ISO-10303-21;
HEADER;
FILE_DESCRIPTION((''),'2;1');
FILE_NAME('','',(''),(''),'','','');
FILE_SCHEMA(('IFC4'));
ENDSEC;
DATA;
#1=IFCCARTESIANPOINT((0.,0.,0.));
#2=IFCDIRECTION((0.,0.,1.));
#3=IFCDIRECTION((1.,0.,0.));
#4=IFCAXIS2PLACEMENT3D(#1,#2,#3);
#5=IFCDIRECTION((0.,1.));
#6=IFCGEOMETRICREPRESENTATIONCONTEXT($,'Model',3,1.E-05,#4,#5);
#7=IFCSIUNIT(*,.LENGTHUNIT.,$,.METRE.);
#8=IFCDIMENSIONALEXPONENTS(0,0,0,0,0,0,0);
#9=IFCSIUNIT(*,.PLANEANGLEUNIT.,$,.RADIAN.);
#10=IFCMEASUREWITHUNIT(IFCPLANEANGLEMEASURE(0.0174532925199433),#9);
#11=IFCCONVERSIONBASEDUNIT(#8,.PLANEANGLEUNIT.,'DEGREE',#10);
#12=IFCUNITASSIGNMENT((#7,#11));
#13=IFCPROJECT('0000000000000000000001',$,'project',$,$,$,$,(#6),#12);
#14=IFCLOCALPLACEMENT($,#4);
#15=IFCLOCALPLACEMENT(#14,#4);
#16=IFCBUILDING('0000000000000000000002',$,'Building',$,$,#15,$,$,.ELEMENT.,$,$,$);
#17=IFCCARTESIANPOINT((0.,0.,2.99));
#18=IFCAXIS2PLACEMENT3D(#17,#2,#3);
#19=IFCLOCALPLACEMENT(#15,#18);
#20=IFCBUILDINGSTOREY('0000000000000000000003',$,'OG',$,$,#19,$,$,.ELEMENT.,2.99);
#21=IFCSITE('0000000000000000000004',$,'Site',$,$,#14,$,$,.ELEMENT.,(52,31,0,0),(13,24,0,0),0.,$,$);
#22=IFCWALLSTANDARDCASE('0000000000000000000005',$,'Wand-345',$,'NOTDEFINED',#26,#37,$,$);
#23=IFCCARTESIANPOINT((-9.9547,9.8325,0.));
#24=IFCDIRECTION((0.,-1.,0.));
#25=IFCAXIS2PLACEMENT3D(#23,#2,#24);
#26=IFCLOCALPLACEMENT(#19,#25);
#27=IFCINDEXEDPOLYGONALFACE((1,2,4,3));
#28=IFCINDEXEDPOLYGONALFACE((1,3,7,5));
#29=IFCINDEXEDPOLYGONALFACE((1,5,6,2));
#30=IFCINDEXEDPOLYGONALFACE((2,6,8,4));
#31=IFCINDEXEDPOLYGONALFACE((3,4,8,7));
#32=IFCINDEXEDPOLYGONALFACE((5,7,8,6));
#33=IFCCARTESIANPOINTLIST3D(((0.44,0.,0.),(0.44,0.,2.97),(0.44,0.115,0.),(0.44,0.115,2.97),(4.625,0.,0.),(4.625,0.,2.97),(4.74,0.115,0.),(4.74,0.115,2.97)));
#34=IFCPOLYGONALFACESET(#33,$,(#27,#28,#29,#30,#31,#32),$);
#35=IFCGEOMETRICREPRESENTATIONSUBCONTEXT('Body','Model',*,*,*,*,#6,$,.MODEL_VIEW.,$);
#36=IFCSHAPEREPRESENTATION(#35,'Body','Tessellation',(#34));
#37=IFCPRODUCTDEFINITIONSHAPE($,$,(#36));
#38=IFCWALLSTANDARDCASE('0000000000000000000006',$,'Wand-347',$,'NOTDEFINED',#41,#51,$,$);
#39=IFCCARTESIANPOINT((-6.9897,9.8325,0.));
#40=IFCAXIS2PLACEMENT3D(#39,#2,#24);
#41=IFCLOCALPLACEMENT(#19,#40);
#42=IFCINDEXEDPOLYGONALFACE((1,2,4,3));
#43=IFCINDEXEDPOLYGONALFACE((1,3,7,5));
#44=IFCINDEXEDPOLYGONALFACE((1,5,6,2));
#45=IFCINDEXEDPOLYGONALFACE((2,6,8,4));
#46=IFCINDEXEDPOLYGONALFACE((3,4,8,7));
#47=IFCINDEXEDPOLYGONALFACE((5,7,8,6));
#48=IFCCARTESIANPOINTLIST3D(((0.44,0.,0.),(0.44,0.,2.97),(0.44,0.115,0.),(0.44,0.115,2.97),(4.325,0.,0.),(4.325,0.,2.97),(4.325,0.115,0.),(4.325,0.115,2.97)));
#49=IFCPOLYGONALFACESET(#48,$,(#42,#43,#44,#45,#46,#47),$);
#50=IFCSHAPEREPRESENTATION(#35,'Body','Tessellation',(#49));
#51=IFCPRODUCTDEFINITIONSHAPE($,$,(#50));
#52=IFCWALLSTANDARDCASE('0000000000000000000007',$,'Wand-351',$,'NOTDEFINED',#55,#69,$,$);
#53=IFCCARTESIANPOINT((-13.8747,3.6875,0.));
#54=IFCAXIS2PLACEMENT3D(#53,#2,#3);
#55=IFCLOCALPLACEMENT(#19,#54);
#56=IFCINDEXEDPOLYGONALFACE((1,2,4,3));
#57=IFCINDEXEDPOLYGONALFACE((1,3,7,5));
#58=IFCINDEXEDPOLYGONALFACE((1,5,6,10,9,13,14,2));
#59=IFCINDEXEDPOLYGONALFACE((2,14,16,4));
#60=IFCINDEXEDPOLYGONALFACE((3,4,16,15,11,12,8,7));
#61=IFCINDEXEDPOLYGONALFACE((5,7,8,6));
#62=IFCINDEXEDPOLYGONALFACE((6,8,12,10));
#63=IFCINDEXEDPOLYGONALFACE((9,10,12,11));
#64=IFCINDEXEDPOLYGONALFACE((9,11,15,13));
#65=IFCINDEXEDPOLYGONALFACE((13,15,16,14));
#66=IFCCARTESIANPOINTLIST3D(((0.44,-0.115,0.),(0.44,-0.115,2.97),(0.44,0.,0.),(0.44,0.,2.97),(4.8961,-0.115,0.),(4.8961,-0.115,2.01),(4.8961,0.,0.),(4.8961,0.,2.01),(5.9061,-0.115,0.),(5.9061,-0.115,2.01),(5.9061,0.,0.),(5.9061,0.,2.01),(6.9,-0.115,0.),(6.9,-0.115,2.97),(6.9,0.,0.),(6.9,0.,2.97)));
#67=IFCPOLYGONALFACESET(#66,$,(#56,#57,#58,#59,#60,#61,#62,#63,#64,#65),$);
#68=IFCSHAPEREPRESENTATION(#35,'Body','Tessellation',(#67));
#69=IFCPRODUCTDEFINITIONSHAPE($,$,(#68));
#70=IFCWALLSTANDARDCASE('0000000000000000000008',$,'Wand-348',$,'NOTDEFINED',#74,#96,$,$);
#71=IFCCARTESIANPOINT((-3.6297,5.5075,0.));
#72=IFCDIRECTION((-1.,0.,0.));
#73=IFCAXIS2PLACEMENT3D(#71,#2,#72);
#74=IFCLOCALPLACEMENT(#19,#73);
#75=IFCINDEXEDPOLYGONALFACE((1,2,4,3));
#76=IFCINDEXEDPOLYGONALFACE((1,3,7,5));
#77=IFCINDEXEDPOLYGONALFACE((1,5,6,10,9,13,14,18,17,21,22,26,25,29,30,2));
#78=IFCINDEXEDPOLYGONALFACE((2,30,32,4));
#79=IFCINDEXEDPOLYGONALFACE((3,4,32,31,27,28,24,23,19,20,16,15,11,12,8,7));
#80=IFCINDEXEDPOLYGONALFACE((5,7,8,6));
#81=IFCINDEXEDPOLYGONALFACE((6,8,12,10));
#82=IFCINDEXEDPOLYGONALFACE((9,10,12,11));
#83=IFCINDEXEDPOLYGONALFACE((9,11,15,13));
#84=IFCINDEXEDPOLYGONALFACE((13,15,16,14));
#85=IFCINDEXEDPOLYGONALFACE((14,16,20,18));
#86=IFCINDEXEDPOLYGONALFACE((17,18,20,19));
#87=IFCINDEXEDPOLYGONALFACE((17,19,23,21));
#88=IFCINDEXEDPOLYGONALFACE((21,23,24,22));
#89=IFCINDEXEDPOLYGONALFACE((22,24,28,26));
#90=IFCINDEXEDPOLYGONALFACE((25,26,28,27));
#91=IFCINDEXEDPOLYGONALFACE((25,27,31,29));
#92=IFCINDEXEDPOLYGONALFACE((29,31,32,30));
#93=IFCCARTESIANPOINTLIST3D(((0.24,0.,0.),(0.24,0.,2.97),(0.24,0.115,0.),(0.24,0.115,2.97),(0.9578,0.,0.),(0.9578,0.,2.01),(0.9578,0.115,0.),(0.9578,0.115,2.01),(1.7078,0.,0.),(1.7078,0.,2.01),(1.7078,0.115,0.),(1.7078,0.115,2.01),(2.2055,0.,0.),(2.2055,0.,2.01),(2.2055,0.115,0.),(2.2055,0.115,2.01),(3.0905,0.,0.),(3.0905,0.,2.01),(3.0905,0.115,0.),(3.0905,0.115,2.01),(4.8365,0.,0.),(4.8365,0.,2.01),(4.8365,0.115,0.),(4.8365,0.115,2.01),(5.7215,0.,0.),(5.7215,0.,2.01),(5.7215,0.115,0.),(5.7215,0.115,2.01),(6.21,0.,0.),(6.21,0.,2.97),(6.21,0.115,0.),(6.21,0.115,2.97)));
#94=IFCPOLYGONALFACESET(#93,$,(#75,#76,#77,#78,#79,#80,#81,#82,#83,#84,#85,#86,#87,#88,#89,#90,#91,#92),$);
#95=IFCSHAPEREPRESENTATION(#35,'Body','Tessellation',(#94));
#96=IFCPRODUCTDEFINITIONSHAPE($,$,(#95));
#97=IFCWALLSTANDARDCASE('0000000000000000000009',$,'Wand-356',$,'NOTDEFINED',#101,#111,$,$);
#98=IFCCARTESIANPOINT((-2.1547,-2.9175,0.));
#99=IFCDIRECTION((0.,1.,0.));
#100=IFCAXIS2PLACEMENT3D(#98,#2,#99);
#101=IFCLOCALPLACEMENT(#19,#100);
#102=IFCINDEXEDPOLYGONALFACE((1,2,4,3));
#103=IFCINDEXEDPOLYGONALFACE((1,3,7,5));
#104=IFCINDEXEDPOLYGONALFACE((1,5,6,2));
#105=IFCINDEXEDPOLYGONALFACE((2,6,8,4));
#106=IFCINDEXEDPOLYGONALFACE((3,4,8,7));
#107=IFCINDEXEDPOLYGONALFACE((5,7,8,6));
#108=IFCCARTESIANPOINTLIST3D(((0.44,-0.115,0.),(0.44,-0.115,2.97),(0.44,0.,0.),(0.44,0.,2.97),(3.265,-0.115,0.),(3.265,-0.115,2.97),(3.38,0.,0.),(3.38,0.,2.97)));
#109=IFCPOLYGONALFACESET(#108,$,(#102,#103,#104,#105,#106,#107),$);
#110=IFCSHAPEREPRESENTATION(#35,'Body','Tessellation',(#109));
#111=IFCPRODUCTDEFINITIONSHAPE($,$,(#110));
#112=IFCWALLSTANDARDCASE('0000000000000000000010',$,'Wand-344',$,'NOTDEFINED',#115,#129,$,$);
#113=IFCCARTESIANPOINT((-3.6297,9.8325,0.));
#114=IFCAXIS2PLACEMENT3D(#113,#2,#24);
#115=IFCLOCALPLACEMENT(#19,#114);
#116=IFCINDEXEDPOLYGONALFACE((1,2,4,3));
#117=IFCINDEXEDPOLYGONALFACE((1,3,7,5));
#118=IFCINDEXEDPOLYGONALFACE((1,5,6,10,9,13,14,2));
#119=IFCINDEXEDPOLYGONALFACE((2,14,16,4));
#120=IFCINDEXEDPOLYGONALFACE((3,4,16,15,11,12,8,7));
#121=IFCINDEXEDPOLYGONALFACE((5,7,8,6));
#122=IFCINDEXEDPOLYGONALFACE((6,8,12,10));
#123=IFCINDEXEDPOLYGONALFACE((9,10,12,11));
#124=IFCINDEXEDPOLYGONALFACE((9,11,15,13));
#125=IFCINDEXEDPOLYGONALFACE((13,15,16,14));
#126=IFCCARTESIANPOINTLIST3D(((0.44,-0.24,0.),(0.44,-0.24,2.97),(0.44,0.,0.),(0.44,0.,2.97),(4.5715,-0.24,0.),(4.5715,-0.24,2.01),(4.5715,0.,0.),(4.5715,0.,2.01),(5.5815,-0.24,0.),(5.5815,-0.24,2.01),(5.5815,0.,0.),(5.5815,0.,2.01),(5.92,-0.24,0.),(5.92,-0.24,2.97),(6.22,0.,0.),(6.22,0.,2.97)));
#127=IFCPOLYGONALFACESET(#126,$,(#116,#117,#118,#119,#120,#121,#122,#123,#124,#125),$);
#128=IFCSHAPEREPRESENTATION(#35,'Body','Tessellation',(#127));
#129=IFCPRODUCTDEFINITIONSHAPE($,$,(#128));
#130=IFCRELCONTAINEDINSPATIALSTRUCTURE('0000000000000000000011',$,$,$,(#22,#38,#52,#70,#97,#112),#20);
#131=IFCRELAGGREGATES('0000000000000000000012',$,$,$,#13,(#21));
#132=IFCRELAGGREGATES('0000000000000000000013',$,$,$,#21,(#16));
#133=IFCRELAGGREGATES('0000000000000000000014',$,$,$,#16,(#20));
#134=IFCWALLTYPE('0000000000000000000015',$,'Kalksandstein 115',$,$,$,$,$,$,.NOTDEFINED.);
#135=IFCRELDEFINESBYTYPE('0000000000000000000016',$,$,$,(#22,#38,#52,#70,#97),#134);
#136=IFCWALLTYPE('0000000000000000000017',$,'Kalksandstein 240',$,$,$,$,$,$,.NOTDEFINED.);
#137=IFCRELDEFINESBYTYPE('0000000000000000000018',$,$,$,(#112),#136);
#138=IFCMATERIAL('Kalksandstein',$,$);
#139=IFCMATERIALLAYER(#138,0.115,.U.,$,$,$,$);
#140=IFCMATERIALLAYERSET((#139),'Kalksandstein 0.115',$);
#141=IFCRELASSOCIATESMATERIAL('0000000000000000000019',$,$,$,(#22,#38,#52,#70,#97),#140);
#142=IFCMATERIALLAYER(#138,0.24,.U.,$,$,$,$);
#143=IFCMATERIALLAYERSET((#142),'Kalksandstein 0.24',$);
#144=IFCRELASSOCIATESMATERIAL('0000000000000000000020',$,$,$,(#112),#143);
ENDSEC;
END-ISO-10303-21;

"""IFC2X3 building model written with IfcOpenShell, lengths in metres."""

from ifc_helpers import new_model, entity, si_unit, converted_unit, direction, frame, origin_with_axes, origin_2d_with_axis, place, context, subcontext, project, spatial, polyline, rectangle, outline, extrude, material, layer, layer_set, layer_usage, type_object, element, save


model = new_model("IFC2X3")

# Units and contexts
model_context = context("Model", 3, precision=1e-05, world=origin_with_axes(), true_north=direction((0.0, 1.0)))
body_context = subcontext(model_context, "Body", "Model", "MODEL_VIEW")
ifc_project = project(units=[si_unit("LENGTHUNIT", "METRE"), converted_unit("PLANEANGLEUNIT", "DEGREE", entity("IfcPlaneAngleMeasure", 0.0174532925199433), si_unit("PLANEANGLEUNIT", "RADIAN"), dimensions=[0, 0, 0, 0, 0, 0, 0])], contexts=[model_context])

# Site, building, storey
site_placement = place(None, origin_with_axes())
site = spatial("IfcSite", under=ifc_project, at=site_placement, Name="Site", CompositionType="ELEMENT", RefLatitude=(52, 31, 0, 0), RefLongitude=(13, 24, 0, 0), RefElevation=0.0)
building_placement = place(site_placement, origin_with_axes())
building = spatial("IfcBuilding", under=site, at=building_placement, Name="Building", CompositionType="ELEMENT")
storey_placement = place(building_placement, frame((0.0, 0.0, 2.99), z_axis=(0.0, 0.0, 1.0), x_axis=(1.0, 0.0, 0.0)))
storey = spatial("IfcBuildingStorey", under=building, at=storey_placement, Name="OG", CompositionType="ELEMENT", Elevation=2.99)

# Shared definitions
ifc_material_1 = material(Name="Kalksandstein")

# Shared definitions
ifc_layer_1 = layer(ifc_material_1, 0.115, ventilated="UNKNOWN")
ifc_layer_set_1 = layer_set([ifc_layer_1], Name="Kalksandstein 0.115")
wall_type_1 = type_object("IfcWallType", Name="Kalksandstein 115", PredefinedType="NOTDEFINED")

# Walls
ifc_layer_usage_1 = layer_usage(ifc_layer_set_1, "AXIS2", "NEGATIVE", 0.115)
wall_1_placement = place(storey_placement, frame((-9.9547, 9.8325, 0.0), z_axis=(0.0, 0.0, 1.0), x_axis=(0.0, -1.0, 0.0)))
element("IfcWallStandardCase", 1, at=wall_1_placement, inside=storey, type_object=wall_type_1, material=ifc_layer_usage_1, Name="Wand-345", ObjectType="NOTDEFINED", context=body_context, shape_type="SweptSolid", body=[
    extrude(outline(polyline([(0.44, 0.0), (4.625, 0.0), (4.74, 0.115), (0.44, 0.115), (0.44, 0.0)])), origin_with_axes(), (0.0, 0.0, 1.0), 2.97),
])
ifc_layer_usage_2 = layer_usage(ifc_layer_set_1, "AXIS2", "NEGATIVE", 0.115)
wall_2_placement = place(storey_placement, frame((-6.9897, 9.8325, 0.0), z_axis=(0.0, 0.0, 1.0), x_axis=(0.0, -1.0, 0.0)))
element("IfcWallStandardCase", 2, at=wall_2_placement, inside=storey, type_object=wall_type_1, material=ifc_layer_usage_2, Name="Wand-347", ObjectType="NOTDEFINED", context=body_context, shape_type="SweptSolid", body=[
    extrude(outline(polyline([(0.44, 0.0), (4.325, 0.0), (4.325, 0.115), (0.44, 0.115), (0.44, 0.0)])), origin_with_axes(), (0.0, 0.0, 1.0), 2.97),
])

# Wall, opening
ifc_layer_usage_3 = layer_usage(ifc_layer_set_1, "AXIS2", "POSITIVE", -0.115)
wall_3_placement = place(storey_placement, frame((-13.8747, 3.6875, 0.0), z_axis=(0.0, 0.0, 1.0), x_axis=(1.0, 0.0, 0.0)))
wall_3 = element("IfcWallStandardCase", 3, at=wall_3_placement, inside=storey, type_object=wall_type_1, material=ifc_layer_usage_3, Name="Wand-351", ObjectType="NOTDEFINED", context=body_context, shape_type="SweptSolid", body=[
    extrude(outline(polyline([(0.44, -0.115), (6.9, -0.115), (6.9, 0.0), (0.44, 0.0), (0.44, -0.115)])), origin_with_axes(), (0.0, 0.0, 1.0), 2.97),
])
opening_1_placement = place(wall_3_placement, frame((5.4011, 0.0, 0.0), z_axis=(0.0, 0.0, 1.0), x_axis=(1.0, 0.0, 0.0)))
element("IfcOpeningElement", 4, at=opening_1_placement, cuts=wall_3, context=body_context, shape_type="SweptSolid", body=[
    extrude(rectangle(XDim=1.01, YDim=2.01, at=origin_2d_with_axis()), frame((0.0, 0.115, 1.005), z_axis=(0.0, 1.0, 0.0), x_axis=(1.0, 0.0, 0.0)), (0.0, 0.0, -1.0), 0.345),
])

# Wall, openings
ifc_layer_usage_4 = layer_usage(ifc_layer_set_1, "AXIS2", "NEGATIVE", 0.115)
wall_4_placement = place(storey_placement, frame((-3.6297, 5.5075, 0.0), z_axis=(0.0, 0.0, 1.0), x_axis=(-1.0, 0.0, 0.0)))
wall_4 = element("IfcWallStandardCase", 5, at=wall_4_placement, inside=storey, type_object=wall_type_1, material=ifc_layer_usage_4, Name="Wand-348", ObjectType="NOTDEFINED", context=body_context, shape_type="SweptSolid", body=[
    extrude(outline(polyline([(0.24, 0.0), (6.21, 0.0), (6.21, 0.115), (0.24, 0.115), (0.24, 0.0)])), origin_with_axes(), (0.0, 0.0, 1.0), 2.97),
])
opening_2_placement = place(wall_4_placement, frame((5.279, 0.0, 0.0), z_axis=(0.0, 0.0, 1.0), x_axis=(1.0, 0.0, 0.0)))
element("IfcOpeningElement", 6, at=opening_2_placement, cuts=wall_4, context=body_context, shape_type="SweptSolid", body=[
    extrude(rectangle(XDim=0.885, YDim=2.01, at=origin_2d_with_axis()), frame((0.0, 0.115, 1.005), z_axis=(0.0, 1.0, 0.0), x_axis=(1.0, 0.0, 0.0)), (0.0, 0.0, -1.0), 0.345),
])
opening_3_placement = place(wall_4_placement, frame((2.648, 0.0, 0.0), z_axis=(0.0, 0.0, 1.0), x_axis=(1.0, 0.0, 0.0)))
element("IfcOpeningElement", 7, at=opening_3_placement, cuts=wall_4, context=body_context, shape_type="SweptSolid", body=[
    extrude(rectangle(XDim=0.885, YDim=2.01, at=origin_2d_with_axis()), frame((0.0, -0.115, 1.005), z_axis=(0.0, -1.0, 0.0), x_axis=(-1.0, 0.0, 0.0)), (0.0, 0.0, -1.0), 0.345),
])
opening_4_placement = place(wall_4_placement, frame((1.3328, 0.0, 0.0), z_axis=(0.0, 0.0, 1.0), x_axis=(1.0, 0.0, 0.0)))
element("IfcOpeningElement", 8, at=opening_4_placement, cuts=wall_4, context=body_context, shape_type="SweptSolid", body=[
    extrude(rectangle(XDim=0.75, YDim=2.01, at=origin_2d_with_axis()), frame((0.0, -0.115, 1.005), z_axis=(0.0, -1.0, 0.0), x_axis=(-1.0, 0.0, 0.0)), (0.0, 0.0, -1.0), 0.345),
])

# Wall
ifc_layer_usage_5 = layer_usage(ifc_layer_set_1, "AXIS2", "POSITIVE", -0.115)
wall_5_placement = place(storey_placement, frame((-2.1547, -2.9175, 0.0), z_axis=(0.0, 0.0, 1.0), x_axis=(0.0, 1.0, 0.0)))
element("IfcWallStandardCase", 9, at=wall_5_placement, inside=storey, type_object=wall_type_1, material=ifc_layer_usage_5, Name="Wand-356", ObjectType="NOTDEFINED", context=body_context, shape_type="SweptSolid", body=[
    extrude(outline(polyline([(0.44, -0.115), (3.265, -0.115), (3.38, 0.0), (0.44, 0.0), (0.44, -0.115)])), origin_with_axes(), (0.0, 0.0, 1.0), 2.97),
])

# Wall, opening
ifc_layer_2 = layer(ifc_material_1, 0.24, ventilated="UNKNOWN")
ifc_layer_set_2 = layer_set([ifc_layer_2], Name="Kalksandstein 0.24")
ifc_layer_usage_6 = layer_usage(ifc_layer_set_2, "AXIS2", "POSITIVE", -0.24)
wall_type_2 = type_object("IfcWallType", Name="Kalksandstein 240", PredefinedType="NOTDEFINED")
wall_6_placement = place(storey_placement, frame((-3.6297, 9.8325, 0.0), z_axis=(0.0, 0.0, 1.0), x_axis=(0.0, -1.0, 0.0)))
wall_6 = element("IfcWallStandardCase", 10, at=wall_6_placement, inside=storey, type_object=wall_type_2, material=ifc_layer_usage_6, Name="Wand-344", ObjectType="NOTDEFINED", context=body_context, shape_type="SweptSolid", body=[
    extrude(outline(polyline([(0.44, -0.24), (5.92, -0.24), (6.22, 0.0), (0.44, 0.0), (0.44, -0.24)])), origin_with_axes(), (0.0, 0.0, 1.0), 2.97),
])
opening_5_placement = place(wall_6_placement, frame((5.0765, 0.0, 0.0), z_axis=(0.0, 0.0, 1.0), x_axis=(1.0, 0.0, 0.0)))
element("IfcOpeningElement", 11, at=opening_5_placement, cuts=wall_6, context=body_context, shape_type="SweptSolid", body=[
    extrude(rectangle(XDim=1.01, YDim=2.01, at=origin_2d_with_axis()), frame((0.0, 0.24, 1.005), z_axis=(0.0, -1.0, 0.0), x_axis=(-1.0, 0.0, 0.0)), (0.0, 0.0, 1.0), 0.72),
])

save(model, "model.ifc")
